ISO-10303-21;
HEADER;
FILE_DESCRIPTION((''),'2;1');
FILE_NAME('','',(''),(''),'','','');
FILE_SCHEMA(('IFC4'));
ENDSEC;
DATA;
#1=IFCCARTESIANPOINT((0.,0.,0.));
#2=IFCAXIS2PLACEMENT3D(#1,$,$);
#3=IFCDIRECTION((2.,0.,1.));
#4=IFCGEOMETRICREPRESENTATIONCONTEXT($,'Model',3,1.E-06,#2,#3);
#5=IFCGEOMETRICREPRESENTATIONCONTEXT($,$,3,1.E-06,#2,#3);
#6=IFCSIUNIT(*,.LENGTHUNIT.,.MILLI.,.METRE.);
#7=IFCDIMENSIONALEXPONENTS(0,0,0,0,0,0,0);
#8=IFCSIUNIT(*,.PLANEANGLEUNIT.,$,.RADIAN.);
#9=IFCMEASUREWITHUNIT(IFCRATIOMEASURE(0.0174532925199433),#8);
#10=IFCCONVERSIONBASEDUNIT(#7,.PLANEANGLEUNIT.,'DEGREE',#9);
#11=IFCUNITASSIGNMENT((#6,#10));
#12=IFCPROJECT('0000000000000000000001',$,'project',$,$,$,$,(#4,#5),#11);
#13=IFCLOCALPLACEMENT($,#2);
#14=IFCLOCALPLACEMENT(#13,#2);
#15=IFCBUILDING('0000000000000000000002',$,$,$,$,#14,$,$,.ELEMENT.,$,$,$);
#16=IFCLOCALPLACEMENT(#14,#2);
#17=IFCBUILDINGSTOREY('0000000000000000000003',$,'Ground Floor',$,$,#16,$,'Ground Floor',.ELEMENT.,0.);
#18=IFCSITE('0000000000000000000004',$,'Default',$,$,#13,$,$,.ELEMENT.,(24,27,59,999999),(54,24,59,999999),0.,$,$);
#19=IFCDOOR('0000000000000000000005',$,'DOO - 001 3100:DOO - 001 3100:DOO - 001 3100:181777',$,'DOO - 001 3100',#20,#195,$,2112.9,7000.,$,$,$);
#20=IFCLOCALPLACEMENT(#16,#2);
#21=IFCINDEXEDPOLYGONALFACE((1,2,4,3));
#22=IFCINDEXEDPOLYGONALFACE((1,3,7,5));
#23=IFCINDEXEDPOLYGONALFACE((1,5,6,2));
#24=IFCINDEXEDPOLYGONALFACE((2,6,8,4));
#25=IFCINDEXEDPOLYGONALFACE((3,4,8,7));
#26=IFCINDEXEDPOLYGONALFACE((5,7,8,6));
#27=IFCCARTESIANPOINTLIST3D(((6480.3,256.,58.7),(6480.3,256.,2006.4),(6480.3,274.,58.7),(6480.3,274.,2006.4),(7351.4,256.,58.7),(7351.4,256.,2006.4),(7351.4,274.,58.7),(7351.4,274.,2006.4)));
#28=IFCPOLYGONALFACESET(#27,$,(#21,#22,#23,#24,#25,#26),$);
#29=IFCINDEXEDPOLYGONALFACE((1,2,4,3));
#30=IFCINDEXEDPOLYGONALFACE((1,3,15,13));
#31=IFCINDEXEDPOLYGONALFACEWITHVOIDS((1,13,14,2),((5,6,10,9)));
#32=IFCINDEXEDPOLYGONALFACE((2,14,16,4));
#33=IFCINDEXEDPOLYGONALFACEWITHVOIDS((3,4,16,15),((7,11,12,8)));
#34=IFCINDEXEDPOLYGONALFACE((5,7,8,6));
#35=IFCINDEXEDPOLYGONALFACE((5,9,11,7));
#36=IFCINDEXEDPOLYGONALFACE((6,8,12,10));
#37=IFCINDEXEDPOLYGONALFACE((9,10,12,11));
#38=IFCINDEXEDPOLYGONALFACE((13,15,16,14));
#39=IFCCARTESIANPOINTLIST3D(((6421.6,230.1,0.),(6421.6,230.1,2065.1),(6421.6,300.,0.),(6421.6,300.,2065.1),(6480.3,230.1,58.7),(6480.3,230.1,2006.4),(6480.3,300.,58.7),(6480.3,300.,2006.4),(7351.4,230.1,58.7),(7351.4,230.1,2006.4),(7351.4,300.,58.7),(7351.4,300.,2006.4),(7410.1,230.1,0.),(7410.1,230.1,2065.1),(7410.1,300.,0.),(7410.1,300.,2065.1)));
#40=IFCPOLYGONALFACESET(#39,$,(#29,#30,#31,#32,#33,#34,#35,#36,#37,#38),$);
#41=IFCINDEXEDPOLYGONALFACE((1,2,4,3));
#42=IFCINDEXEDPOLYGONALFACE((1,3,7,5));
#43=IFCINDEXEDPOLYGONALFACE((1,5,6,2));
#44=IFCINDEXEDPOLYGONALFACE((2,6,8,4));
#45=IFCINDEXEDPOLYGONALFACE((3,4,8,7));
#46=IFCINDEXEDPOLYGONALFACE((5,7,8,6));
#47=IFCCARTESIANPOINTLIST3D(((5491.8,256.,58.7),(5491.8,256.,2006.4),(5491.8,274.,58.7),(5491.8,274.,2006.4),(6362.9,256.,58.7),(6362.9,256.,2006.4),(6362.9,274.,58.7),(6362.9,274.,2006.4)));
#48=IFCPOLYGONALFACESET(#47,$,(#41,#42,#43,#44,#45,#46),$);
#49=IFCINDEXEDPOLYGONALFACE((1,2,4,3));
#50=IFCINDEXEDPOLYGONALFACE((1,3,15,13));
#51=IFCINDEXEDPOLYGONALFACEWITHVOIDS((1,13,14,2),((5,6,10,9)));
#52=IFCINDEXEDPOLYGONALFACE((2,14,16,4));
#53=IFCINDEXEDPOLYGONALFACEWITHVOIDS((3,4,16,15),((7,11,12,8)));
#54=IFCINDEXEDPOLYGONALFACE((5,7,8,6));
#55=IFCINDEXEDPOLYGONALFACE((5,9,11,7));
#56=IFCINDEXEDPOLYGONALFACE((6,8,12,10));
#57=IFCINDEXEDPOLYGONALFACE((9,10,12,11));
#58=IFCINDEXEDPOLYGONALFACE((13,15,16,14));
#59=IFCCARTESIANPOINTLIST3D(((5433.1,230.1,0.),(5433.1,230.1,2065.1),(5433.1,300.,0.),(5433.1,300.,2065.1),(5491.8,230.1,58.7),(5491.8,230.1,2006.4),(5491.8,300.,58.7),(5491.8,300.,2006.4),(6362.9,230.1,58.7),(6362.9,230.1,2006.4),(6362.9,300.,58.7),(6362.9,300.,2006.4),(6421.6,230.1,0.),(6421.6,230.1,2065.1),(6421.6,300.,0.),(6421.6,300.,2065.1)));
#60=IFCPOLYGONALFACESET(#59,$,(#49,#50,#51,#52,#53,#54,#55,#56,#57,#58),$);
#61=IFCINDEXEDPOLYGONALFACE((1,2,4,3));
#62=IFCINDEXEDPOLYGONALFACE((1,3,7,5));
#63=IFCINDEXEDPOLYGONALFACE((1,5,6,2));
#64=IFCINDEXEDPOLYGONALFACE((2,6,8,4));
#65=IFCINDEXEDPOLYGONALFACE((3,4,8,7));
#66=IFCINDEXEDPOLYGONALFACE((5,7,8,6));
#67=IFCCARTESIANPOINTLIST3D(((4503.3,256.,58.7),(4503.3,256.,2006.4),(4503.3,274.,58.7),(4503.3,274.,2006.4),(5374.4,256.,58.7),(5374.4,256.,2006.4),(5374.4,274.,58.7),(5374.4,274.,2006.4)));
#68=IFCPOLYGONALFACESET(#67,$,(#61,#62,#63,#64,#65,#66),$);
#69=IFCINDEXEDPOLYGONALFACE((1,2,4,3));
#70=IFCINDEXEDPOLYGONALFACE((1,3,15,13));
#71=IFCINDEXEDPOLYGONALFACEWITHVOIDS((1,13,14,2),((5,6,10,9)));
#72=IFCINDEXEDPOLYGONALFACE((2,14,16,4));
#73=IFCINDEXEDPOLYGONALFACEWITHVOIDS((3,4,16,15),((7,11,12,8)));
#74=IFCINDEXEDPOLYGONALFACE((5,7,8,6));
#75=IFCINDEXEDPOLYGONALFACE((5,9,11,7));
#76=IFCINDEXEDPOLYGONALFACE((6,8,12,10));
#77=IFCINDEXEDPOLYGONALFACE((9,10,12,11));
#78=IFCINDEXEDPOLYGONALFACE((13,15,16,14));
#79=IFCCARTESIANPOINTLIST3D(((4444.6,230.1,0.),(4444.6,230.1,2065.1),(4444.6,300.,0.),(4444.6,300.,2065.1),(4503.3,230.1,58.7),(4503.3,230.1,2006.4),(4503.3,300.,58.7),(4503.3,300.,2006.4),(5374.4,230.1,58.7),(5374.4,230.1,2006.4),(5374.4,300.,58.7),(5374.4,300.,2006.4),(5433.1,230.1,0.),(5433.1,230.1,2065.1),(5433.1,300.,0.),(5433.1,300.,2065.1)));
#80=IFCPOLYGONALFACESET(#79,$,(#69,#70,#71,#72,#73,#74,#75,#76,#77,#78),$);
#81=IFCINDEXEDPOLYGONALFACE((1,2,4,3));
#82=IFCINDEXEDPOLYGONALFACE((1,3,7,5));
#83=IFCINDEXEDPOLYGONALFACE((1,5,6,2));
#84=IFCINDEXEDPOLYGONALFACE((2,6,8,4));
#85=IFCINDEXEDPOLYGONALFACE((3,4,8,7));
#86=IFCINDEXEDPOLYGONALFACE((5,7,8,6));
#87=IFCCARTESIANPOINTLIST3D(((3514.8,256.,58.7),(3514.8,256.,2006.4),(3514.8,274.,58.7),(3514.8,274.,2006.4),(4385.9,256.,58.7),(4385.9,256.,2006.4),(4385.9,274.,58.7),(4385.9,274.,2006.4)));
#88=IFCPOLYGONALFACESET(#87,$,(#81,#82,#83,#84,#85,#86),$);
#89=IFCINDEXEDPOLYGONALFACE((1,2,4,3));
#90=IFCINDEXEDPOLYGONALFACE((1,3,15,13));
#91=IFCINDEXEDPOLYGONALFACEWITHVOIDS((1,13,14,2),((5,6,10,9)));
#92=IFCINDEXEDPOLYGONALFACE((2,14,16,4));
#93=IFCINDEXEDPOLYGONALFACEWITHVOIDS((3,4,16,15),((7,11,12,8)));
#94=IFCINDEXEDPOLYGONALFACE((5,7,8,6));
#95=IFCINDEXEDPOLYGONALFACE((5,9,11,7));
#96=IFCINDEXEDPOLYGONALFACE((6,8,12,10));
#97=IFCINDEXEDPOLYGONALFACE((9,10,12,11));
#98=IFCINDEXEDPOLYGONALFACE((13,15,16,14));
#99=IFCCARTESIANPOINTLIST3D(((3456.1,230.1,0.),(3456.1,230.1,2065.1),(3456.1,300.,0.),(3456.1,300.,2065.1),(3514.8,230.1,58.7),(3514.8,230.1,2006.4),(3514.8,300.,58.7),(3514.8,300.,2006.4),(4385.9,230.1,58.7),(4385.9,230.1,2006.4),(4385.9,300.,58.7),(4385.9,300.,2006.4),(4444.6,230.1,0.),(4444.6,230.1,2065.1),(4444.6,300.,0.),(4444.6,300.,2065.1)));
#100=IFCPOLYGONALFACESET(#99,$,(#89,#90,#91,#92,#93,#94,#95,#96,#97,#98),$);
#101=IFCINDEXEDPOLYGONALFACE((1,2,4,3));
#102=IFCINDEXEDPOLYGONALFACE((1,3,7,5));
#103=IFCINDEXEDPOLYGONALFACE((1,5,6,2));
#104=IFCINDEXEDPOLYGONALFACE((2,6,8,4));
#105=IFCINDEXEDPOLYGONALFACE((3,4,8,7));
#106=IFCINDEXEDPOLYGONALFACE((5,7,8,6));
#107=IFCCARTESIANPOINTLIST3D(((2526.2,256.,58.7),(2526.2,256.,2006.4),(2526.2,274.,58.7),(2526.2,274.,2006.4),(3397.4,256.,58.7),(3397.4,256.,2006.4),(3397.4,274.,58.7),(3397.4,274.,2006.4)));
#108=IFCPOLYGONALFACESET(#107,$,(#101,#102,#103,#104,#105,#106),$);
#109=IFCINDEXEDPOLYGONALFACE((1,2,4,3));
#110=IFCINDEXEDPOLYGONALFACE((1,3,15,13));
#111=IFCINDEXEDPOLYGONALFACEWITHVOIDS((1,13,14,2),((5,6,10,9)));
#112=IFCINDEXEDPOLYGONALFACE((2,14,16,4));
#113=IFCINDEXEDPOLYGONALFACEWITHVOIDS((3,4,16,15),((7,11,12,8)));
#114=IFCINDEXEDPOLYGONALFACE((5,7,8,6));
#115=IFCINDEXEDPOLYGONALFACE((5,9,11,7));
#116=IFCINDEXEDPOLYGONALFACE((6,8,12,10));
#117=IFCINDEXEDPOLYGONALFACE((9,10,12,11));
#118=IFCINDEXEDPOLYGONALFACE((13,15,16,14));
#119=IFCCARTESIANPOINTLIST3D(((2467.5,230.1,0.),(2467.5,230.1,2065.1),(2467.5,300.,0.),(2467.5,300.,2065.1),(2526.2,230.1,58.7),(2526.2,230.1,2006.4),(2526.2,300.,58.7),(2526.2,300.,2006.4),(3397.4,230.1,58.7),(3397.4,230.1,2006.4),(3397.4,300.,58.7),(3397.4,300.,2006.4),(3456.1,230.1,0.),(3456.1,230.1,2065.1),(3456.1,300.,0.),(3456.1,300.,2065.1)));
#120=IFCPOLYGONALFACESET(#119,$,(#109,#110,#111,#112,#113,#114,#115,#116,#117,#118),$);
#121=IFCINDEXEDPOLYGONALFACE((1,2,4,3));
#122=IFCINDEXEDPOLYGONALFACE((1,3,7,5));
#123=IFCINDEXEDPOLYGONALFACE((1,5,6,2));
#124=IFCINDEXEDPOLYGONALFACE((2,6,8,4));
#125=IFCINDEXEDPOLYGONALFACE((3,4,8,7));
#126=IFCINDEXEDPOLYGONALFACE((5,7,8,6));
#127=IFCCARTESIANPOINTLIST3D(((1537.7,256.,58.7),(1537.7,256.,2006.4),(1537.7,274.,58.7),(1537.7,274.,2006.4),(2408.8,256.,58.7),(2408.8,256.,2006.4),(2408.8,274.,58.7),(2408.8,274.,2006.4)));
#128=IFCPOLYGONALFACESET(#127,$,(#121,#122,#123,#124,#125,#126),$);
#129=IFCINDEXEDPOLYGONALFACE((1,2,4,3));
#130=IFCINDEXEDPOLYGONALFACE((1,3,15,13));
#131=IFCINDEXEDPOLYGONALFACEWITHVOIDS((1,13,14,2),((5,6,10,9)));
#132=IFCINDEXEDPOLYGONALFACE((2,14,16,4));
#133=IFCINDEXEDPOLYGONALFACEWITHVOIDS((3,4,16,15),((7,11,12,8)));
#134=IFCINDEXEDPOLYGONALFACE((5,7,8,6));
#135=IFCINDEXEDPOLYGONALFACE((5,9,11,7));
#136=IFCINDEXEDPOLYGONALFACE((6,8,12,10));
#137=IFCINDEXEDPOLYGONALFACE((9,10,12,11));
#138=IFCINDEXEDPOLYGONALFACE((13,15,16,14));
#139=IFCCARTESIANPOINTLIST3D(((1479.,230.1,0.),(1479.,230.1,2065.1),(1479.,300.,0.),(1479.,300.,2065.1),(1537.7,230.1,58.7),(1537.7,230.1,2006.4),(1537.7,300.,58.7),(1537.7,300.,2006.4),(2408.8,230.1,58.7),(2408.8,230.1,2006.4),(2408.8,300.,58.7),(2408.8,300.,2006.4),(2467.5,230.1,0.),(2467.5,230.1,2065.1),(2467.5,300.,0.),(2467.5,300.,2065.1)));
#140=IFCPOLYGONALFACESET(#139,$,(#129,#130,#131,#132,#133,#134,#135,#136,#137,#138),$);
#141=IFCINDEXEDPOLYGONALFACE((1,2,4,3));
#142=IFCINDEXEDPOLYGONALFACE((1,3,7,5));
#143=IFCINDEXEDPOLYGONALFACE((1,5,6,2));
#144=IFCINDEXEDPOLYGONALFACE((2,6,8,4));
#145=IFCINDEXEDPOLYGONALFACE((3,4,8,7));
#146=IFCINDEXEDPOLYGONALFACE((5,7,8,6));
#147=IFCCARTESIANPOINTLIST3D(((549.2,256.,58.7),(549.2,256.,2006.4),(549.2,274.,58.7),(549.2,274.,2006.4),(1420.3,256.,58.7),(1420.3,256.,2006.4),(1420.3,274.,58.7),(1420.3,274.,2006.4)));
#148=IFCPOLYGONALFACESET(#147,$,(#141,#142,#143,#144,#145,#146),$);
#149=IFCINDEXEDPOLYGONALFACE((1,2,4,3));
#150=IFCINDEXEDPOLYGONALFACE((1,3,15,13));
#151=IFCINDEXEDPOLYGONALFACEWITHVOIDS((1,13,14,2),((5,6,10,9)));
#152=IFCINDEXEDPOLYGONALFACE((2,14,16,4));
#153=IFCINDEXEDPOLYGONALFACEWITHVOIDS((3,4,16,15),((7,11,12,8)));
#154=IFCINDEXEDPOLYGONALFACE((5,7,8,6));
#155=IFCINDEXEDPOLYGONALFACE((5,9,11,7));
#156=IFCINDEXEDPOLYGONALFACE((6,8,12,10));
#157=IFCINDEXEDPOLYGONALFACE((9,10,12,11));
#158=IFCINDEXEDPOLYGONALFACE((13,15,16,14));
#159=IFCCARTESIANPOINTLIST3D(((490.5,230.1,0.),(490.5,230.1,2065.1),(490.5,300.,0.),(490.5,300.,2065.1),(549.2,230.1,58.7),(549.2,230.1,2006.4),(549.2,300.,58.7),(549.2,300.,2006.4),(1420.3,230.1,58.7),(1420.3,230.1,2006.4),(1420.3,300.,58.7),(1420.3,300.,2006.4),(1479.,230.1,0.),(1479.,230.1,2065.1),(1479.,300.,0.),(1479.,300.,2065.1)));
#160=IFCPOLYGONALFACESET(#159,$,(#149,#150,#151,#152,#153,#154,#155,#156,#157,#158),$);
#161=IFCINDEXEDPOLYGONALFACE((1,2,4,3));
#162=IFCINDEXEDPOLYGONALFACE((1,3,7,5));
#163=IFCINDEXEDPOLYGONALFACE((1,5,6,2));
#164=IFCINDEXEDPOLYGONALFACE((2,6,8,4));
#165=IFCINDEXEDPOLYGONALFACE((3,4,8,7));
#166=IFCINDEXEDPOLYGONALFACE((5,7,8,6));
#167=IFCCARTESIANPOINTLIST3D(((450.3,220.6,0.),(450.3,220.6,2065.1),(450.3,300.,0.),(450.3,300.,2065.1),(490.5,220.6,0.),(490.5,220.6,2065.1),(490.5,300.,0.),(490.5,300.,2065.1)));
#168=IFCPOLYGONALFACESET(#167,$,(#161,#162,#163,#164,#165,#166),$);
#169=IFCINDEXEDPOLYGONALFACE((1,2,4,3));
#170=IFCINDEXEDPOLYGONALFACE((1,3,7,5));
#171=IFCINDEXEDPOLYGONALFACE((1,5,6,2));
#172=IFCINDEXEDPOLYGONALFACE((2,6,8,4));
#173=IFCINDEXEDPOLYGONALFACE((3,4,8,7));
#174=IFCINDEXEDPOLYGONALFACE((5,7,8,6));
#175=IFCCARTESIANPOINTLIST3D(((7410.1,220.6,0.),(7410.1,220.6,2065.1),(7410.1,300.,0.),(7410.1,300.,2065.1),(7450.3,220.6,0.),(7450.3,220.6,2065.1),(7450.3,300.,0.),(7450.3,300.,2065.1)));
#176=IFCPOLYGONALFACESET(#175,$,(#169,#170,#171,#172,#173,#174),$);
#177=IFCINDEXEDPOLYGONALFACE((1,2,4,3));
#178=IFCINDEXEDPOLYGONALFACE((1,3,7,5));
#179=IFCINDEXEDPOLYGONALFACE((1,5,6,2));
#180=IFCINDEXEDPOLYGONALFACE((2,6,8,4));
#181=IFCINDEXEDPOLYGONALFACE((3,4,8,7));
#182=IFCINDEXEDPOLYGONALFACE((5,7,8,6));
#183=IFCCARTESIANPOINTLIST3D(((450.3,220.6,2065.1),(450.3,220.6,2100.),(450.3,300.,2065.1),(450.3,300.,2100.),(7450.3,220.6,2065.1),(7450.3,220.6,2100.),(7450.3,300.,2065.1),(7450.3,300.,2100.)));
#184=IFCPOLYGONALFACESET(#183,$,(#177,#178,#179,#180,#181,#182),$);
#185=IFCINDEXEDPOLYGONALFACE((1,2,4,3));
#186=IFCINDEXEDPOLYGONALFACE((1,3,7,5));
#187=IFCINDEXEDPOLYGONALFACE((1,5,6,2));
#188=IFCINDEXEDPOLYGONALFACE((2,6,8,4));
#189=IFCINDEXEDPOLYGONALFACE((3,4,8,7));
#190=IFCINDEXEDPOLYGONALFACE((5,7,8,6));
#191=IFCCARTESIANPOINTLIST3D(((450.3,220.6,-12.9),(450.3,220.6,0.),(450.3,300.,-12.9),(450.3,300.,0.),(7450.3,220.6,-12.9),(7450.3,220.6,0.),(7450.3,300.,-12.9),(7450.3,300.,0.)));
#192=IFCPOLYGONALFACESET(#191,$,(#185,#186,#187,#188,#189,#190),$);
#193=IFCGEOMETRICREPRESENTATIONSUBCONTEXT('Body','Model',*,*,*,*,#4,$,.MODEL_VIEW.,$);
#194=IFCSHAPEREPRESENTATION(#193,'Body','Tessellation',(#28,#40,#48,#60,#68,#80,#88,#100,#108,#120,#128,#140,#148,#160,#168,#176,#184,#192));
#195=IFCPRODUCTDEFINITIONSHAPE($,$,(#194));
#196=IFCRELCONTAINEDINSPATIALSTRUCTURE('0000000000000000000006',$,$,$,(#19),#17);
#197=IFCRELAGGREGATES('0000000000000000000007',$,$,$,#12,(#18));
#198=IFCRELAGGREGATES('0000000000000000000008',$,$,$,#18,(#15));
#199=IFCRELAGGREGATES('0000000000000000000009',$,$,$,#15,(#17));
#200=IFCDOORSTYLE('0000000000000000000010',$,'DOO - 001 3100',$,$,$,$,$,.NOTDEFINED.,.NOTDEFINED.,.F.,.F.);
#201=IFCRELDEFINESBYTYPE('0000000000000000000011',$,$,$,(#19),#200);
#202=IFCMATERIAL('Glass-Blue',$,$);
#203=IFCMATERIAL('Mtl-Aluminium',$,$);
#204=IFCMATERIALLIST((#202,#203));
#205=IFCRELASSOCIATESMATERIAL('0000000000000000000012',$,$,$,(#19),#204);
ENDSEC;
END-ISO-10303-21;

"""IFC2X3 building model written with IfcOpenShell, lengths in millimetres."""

from ifc_helpers import new_model, entity, si_unit, converted_unit, direction, frame, frame_2d, origin, place, context, subcontext, project, spatial, polyline, rectangle, outline, extrude, source, transform, mapped, material, material_list, type_object, type_shapes, element, save


model = new_model("IFC2X3")

# Units and contexts
model_context = context("Model", 3, precision=1e-06, world=origin(), true_north=direction((2.0, 0.0, 1.0)))
context_of_model = context(None, 3, precision=1e-06, world=origin(), true_north=direction((2.0, 0.0, 1.0)))
body_context = subcontext(model_context, "Body", "Model", "MODEL_VIEW")
ifc_project = project(units=[si_unit("LENGTHUNIT", "METRE", prefix="MILLI"), converted_unit("PLANEANGLEUNIT", "DEGREE", entity("IfcRatioMeasure", 0.0174532925199433), si_unit("PLANEANGLEUNIT", "RADIAN"), dimensions=[0, 0, 0, 0, 0, 0, 0])], contexts=[model_context, context_of_model])

# Site, building, storey
site_placement = place(None, origin())
site = spatial("IfcSite", under=ifc_project, at=site_placement, Name="Default", CompositionType="ELEMENT", RefLatitude=(24, 27, 59, 999999), RefLongitude=(54, 24, 59, 999999), RefElevation=0.0)
building_placement = place(site_placement, origin())
building = spatial("IfcBuilding", under=site, at=building_placement, CompositionType="ELEMENT")
storey_placement = place(building_placement, origin())
storey = spatial("IfcBuildingStorey", under=building, at=storey_placement, Name="Ground Floor", LongName="Ground Floor", CompositionType="ELEMENT", Elevation=0.0)

# Door
ifc_material_1 = material(Name="Glass-Blue")
ifc_material_2 = material(Name="Mtl-Aluminium")
ifc_material_list = material_list([ifc_material_1, ifc_material_2])
door_style = type_object("IfcDoorStyle", Name="DOO - 001 3100", ConstructionType="NOTDEFINED", OperationType="NOTDEFINED", ParameterTakesPrecedence=False, Sizeable=False)
shared_shape = source(origin(), body_context, "Body", "SweptSolid", [
    extrude(rectangle(XDim=871.1, YDim=18.0, at=frame_2d((0.0, 0.0), x_axis=(1.0, 0.0))), frame((6915.9, 265.1, 58.7), z_axis=(0.0, 0.0, 1.0), x_axis=(-1.0, 0.0, 0.0)), (0.0, 0.0, 1.0), 1947.7),
    extrude(outline(polyline([(-494.3, -1032.5), (494.3, -1032.5), (494.3, 1032.5), (-494.3, 1032.5), (-494.3, -1032.5)]), holes=[polyline([(435.6, 973.9), (435.6, -973.9), (-435.6, -973.9), (-435.6, 973.9), (435.6, 973.9)])]), frame((6915.9, 230.1, 1032.5), z_axis=(0.0, 1.0, 0.0), x_axis=(-1.0, 0.0, 0.0)), (0.0, 0.0, 1.0), 69.9),
    extrude(rectangle(XDim=871.1, YDim=18.0, at=frame_2d((0.0, 0.0), x_axis=(1.0, 0.0))), frame((5927.3, 265.1, 58.7), z_axis=(0.0, 0.0, 1.0), x_axis=(-1.0, 0.0, 0.0)), (0.0, 0.0, 1.0), 1947.7),
    extrude(outline(polyline([(-494.3, -1032.5), (494.3, -1032.5), (494.3, 1032.5), (-494.3, 1032.5), (-494.3, -1032.5)]), holes=[polyline([(435.6, 973.9), (435.6, -973.9), (-435.6, -973.9), (-435.6, 973.9), (435.6, 973.9)])]), frame((5927.3, 230.1, 1032.5), z_axis=(0.0, 1.0, 0.0), x_axis=(-1.0, 0.0, 0.0)), (0.0, 0.0, 1.0), 69.9),
    extrude(rectangle(XDim=871.1, YDim=18.0, at=frame_2d((0.0, 0.0), x_axis=(1.0, 0.0))), frame((4938.8, 265.1, 58.7), z_axis=(0.0, 0.0, 1.0), x_axis=(-1.0, 0.0, 0.0)), (0.0, 0.0, 1.0), 1947.7),
    extrude(outline(polyline([(-494.3, -1032.5), (494.3, -1032.5), (494.3, 1032.5), (-494.3, 1032.5), (-494.3, -1032.5)]), holes=[polyline([(435.6, 973.9), (435.6, -973.9), (-435.6, -973.9), (-435.6, 973.9), (435.6, 973.9)])]), frame((4938.8, 230.1, 1032.5), z_axis=(0.0, 1.0, 0.0), x_axis=(-1.0, 0.0, 0.0)), (0.0, 0.0, 1.0), 69.9),
    extrude(rectangle(XDim=871.1, YDim=18.0, at=frame_2d((0.0, 0.0), x_axis=(1.0, 0.0))), frame((3950.3, 265.1, 58.7), z_axis=(0.0, 0.0, 1.0), x_axis=(-1.0, 0.0, 0.0)), (0.0, 0.0, 1.0), 1947.7),
    extrude(outline(polyline([(-494.3, -1032.5), (494.3, -1032.5), (494.3, 1032.5), (-494.3, 1032.5), (-494.3, -1032.5)]), holes=[polyline([(435.6, 973.9), (435.6, -973.9), (-435.6, -973.9), (-435.6, 973.9), (435.6, 973.9)])]), frame((3950.3, 230.1, 1032.5), z_axis=(0.0, 1.0, 0.0), x_axis=(-1.0, 0.0, 0.0)), (0.0, 0.0, 1.0), 69.9),
    extrude(rectangle(XDim=871.1, YDim=18.0, at=frame_2d((0.0, 0.0), x_axis=(1.0, 0.0))), frame((2961.8, 265.1, 58.7), z_axis=(0.0, 0.0, 1.0), x_axis=(-1.0, 0.0, 0.0)), (0.0, 0.0, 1.0), 1947.7),
    extrude(outline(polyline([(-494.3, -1032.5), (494.3, -1032.5), (494.3, 1032.5), (-494.3, 1032.5), (-494.3, -1032.5)]), holes=[polyline([(435.6, 973.9), (435.6, -973.9), (-435.6, -973.9), (-435.6, 973.9), (435.6, 973.9)])]), frame((2961.8, 230.1, 1032.5), z_axis=(0.0, 1.0, 0.0), x_axis=(-1.0, 0.0, 0.0)), (0.0, 0.0, 1.0), 69.9),
    extrude(rectangle(XDim=871.1, YDim=18.0, at=frame_2d((0.0, 0.0), x_axis=(1.0, 0.0))), frame((1973.3, 265.1, 58.7), z_axis=(0.0, 0.0, 1.0), x_axis=(-1.0, 0.0, 0.0)), (0.0, 0.0, 1.0), 1947.7),
    extrude(outline(polyline([(-494.3, -1032.5), (494.3, -1032.5), (494.3, 1032.5), (-494.3, 1032.5), (-494.3, -1032.5)]), holes=[polyline([(435.6, 973.9), (435.6, -973.9), (-435.6, -973.9), (-435.6, 973.9), (435.6, 973.9)])]), frame((1973.3, 230.1, 1032.5), z_axis=(0.0, 1.0, 0.0), x_axis=(-1.0, 0.0, 0.0)), (0.0, 0.0, 1.0), 69.9),
    extrude(rectangle(XDim=871.1, YDim=18.0, at=frame_2d((0.0, 0.0), x_axis=(1.0, 0.0))), frame((984.8, 265.1, 58.7), z_axis=(0.0, 0.0, 1.0), x_axis=(-1.0, 0.0, 0.0)), (0.0, 0.0, 1.0), 1947.7),
    extrude(outline(polyline([(-494.3, -1032.5), (494.3, -1032.5), (494.3, 1032.5), (-494.3, 1032.5), (-494.3, -1032.5)]), holes=[polyline([(435.6, 973.9), (435.6, -973.9), (-435.6, -973.9), (-435.6, 973.9), (435.6, 973.9)])]), frame((984.8, 230.1, 1032.5), z_axis=(0.0, 1.0, 0.0), x_axis=(-1.0, 0.0, 0.0)), (0.0, 0.0, 1.0), 69.9),
    extrude(rectangle(XDim=40.2, YDim=79.4, at=frame_2d((0.0, 0.0), x_axis=(1.0, 0.0))), frame((470.4, 260.3, 0.0), z_axis=(0.0, 0.0, 1.0), x_axis=(-1.0, 0.0, 0.0)), (0.0, 0.0, 1.0), 2065.1),
    extrude(rectangle(XDim=40.2, YDim=79.4, at=frame_2d((0.0, 0.0), x_axis=(1.0, 0.0))), frame((7430.2, 260.3, 0.0), z_axis=(0.0, 0.0, 1.0), x_axis=(-1.0, 0.0, 0.0)), (0.0, 0.0, 1.0), 2065.1),
    extrude(rectangle(XDim=7000.0, YDim=79.4, at=frame_2d((0.0, 0.0), x_axis=(1.0, 0.0))), frame((3950.3, 260.3, 2065.1), z_axis=(0.0, 0.0, 1.0), x_axis=(-1.0, 0.0, 0.0)), (0.0, 0.0, 1.0), 34.9),
    extrude(rectangle(XDim=7000.0, YDim=79.4, at=frame_2d((0.0, 0.0), x_axis=(1.0, 0.0))), frame((3950.3, 260.3, -12.9), z_axis=(0.0, 0.0, 1.0), x_axis=(-1.0, 0.0, 0.0)), (0.0, 0.0, 1.0), 12.9),
])
type_shapes(door_style, [shared_shape])
door_placement = place(storey_placement, origin())
element("IfcDoor", 1, at=door_placement, inside=storey, type_object=door_style, material=ifc_material_list, Name="DOO - 001 3100:DOO - 001 3100:DOO - 001 3100:181777", ObjectType="DOO - 001 3100", OverallHeight=2112.9, OverallWidth=7000.0, context=body_context, shape_type="MappedRepresentation", body=[
    mapped(shared_shape, transform((0.0, 0.0, 0.0), scale=1.0)),
])

save(model, "model.ifc")
